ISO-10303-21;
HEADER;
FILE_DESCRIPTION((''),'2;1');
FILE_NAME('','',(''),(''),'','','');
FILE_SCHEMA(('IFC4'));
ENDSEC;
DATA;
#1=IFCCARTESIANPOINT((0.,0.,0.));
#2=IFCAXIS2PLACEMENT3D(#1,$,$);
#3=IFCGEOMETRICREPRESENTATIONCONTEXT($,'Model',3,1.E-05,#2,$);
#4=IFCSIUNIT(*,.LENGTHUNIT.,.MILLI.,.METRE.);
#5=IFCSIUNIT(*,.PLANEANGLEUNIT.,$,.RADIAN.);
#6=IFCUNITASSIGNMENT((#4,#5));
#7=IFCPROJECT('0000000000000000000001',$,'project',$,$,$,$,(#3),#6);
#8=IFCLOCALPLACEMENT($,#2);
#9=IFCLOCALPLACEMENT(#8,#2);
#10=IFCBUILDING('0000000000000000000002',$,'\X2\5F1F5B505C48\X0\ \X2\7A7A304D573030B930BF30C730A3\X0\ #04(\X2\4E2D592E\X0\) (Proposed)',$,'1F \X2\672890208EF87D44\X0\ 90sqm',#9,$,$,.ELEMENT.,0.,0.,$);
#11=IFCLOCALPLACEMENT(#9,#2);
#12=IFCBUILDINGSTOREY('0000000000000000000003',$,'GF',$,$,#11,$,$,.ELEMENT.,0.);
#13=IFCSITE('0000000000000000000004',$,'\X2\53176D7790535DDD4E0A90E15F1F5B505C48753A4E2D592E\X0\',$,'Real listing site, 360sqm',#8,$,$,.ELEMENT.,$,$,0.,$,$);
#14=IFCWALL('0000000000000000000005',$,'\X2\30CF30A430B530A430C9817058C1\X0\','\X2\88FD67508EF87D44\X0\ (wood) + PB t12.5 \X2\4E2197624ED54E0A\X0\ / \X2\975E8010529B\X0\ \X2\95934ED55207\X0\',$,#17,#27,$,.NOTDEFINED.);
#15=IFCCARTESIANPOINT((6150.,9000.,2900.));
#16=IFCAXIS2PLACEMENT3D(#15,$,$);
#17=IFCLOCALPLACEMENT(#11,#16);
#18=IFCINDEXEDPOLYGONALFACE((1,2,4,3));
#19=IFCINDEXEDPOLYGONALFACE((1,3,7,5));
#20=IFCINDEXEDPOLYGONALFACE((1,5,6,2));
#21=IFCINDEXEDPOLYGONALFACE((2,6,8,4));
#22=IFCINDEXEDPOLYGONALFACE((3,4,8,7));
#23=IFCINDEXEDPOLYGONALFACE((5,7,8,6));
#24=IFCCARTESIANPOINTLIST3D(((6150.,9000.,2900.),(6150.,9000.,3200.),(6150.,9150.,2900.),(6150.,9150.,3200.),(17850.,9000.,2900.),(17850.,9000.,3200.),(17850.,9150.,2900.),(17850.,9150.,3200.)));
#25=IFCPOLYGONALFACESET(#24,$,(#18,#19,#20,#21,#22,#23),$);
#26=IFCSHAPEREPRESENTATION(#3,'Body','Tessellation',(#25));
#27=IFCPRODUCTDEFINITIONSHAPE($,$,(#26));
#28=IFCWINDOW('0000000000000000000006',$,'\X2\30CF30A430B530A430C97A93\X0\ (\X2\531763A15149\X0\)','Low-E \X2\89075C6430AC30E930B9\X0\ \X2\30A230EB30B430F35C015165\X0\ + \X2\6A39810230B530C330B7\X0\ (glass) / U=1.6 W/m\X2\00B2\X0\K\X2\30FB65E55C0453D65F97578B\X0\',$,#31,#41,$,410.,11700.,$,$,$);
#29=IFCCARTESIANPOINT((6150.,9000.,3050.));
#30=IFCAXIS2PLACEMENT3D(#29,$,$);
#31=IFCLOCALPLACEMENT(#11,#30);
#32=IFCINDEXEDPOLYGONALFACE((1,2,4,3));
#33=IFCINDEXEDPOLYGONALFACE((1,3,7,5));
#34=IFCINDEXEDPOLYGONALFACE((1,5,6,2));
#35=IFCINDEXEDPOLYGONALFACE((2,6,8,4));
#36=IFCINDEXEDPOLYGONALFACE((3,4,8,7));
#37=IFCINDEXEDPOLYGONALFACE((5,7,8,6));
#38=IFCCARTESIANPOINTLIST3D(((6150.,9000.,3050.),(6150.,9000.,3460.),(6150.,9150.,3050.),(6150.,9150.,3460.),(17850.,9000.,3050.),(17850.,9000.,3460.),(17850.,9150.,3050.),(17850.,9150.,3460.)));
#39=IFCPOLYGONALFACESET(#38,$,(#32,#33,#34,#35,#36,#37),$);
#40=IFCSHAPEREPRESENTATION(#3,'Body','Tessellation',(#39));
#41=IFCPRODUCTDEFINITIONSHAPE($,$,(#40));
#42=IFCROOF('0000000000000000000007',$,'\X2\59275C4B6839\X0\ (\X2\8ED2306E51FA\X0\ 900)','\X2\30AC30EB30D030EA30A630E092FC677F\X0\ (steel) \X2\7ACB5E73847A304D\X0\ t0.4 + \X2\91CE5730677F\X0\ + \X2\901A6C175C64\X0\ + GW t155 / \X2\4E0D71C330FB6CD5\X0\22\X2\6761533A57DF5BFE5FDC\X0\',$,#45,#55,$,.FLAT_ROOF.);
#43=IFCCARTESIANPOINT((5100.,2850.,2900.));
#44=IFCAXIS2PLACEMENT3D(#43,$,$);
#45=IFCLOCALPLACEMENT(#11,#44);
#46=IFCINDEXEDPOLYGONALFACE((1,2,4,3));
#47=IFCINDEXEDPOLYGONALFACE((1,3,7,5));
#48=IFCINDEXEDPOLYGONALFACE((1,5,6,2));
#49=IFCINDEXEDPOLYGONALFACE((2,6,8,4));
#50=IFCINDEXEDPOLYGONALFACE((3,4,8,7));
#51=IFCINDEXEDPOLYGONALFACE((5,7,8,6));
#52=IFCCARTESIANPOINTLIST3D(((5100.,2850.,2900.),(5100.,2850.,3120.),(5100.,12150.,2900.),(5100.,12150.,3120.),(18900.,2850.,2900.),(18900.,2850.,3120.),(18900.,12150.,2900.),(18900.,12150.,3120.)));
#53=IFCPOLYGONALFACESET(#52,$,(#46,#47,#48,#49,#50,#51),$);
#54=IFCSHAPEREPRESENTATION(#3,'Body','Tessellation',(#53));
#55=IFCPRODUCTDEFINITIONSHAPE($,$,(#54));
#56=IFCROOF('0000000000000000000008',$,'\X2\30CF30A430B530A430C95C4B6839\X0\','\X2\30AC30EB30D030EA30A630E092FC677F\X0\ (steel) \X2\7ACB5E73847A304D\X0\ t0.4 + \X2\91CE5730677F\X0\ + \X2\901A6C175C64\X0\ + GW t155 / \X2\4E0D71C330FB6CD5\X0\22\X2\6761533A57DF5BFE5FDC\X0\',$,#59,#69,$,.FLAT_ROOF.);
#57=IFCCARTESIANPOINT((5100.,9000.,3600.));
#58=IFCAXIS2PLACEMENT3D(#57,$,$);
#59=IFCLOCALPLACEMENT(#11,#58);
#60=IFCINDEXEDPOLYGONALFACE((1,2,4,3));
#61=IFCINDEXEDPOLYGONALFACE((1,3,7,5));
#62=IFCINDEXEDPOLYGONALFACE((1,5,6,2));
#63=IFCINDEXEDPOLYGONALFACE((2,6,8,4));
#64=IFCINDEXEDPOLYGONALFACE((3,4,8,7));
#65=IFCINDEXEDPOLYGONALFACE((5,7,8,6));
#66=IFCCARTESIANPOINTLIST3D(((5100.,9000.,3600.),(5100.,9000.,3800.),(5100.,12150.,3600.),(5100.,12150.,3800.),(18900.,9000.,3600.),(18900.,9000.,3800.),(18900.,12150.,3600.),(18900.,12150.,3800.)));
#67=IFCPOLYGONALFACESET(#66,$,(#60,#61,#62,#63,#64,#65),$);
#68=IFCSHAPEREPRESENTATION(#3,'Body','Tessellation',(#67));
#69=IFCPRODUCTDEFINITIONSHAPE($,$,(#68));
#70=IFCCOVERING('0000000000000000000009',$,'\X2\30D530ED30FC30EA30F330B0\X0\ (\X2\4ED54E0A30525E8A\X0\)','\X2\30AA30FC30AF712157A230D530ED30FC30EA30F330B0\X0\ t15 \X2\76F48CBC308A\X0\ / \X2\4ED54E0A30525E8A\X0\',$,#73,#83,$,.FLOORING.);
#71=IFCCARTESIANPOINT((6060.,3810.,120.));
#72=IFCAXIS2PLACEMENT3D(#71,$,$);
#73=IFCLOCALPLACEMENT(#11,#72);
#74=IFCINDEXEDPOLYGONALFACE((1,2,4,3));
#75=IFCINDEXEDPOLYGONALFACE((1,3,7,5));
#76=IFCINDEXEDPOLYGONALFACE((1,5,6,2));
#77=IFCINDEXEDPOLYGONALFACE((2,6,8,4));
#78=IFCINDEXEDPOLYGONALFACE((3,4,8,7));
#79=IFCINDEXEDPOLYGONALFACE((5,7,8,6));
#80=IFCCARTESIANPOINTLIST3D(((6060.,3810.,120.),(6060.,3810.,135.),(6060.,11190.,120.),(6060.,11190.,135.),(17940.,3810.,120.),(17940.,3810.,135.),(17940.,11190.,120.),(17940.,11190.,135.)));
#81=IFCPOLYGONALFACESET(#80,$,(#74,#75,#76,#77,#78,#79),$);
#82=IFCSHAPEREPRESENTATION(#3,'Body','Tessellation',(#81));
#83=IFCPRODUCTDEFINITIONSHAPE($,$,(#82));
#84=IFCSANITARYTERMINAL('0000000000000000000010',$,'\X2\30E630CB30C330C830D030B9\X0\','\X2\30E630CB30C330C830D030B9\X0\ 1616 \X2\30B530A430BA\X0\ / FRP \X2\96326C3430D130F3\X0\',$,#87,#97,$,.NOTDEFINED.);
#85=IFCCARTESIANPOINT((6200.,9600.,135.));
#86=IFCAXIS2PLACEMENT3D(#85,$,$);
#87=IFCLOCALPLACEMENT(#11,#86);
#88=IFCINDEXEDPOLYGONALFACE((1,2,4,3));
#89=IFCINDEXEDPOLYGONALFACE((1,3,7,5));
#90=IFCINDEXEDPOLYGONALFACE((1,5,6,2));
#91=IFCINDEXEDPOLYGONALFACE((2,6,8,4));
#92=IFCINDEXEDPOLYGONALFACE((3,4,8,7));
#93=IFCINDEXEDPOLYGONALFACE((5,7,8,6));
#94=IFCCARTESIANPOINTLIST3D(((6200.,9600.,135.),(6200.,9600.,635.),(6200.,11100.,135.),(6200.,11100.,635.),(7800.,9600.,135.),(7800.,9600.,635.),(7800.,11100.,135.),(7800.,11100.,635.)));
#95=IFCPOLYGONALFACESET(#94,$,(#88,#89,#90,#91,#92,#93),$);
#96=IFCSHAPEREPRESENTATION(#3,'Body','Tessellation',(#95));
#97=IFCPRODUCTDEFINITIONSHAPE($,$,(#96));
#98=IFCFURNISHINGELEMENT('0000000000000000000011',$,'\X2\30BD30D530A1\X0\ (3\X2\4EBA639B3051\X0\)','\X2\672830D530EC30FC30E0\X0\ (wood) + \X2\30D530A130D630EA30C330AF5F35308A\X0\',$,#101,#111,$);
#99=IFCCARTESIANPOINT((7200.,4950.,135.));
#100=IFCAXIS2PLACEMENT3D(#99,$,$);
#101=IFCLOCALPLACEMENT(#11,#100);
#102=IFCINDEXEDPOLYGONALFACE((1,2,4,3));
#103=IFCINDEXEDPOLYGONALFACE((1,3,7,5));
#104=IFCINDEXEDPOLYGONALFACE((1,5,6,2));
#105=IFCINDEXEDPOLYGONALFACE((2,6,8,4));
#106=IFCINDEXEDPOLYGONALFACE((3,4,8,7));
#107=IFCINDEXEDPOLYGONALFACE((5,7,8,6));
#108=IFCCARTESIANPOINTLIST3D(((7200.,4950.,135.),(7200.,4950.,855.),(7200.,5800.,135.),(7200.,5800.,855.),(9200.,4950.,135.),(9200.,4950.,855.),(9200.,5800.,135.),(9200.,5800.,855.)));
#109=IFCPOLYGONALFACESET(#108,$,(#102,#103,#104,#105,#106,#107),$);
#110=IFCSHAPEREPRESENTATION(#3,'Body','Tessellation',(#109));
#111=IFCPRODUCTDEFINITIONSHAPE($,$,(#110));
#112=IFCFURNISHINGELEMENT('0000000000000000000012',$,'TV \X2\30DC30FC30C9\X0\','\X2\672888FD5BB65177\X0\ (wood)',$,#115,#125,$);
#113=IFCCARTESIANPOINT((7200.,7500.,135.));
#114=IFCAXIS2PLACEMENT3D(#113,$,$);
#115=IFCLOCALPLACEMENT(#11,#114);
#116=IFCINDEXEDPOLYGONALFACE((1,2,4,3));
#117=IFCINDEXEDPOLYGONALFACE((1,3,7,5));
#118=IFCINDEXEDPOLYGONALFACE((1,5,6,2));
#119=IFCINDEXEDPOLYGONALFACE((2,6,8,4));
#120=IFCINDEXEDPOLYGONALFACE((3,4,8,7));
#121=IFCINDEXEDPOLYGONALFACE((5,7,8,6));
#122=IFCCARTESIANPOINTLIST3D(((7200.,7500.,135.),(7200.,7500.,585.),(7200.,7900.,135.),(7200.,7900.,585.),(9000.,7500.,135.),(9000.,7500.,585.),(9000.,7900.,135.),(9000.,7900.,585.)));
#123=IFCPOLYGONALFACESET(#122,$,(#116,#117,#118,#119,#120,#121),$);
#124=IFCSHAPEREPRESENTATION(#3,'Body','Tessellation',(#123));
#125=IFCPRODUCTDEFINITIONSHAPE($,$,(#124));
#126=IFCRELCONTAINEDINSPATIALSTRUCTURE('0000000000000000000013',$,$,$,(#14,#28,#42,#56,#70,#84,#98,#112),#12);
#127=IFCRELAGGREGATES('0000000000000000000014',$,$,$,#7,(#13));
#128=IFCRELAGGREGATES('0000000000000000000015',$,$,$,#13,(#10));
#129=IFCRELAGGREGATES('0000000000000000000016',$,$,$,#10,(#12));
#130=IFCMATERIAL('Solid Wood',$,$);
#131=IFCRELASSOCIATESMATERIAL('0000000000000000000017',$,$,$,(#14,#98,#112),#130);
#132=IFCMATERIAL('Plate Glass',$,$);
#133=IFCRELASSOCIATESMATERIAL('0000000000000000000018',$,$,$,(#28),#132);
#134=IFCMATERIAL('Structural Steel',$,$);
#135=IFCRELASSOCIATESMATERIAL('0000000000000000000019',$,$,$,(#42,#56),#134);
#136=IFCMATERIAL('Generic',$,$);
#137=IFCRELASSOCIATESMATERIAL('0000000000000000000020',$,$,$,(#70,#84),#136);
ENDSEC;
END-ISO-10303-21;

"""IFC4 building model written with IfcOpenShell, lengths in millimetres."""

from ifc_helpers import new_model, si_unit, frame, frame_2d, origin, place, context, project, spatial, rectangle, extrude, material, element, fill, save


model = new_model("IFC4")

# Units and contexts
model_context = context("Model", 3, precision=1e-05, world=origin())
ifc_project = project(units=[si_unit("LENGTHUNIT", "METRE", prefix="MILLI"), si_unit("PLANEANGLEUNIT", "RADIAN")], contexts=[model_context])

# Site, building, storey
site_placement = place(None, origin())
site = spatial("IfcSite", under=ifc_project, at=site_placement, Name="北海道川上郡弟子屈町中央", ObjectType="Real listing site, 360sqm", CompositionType="ELEMENT", RefElevation=0.0)
building_placement = place(site_placement, origin())
building = spatial("IfcBuilding", under=site, at=building_placement, Name="弟子屈 空き地スタディ #04(中央) (Proposed)", ObjectType="1F 木造軸組 90sqm", CompositionType="ELEMENT", ElevationOfRefHeight=0.0, ElevationOfTerrain=0.0)
storey_placement = place(building_placement, origin())
storey = spatial("IfcBuildingStorey", under=building, at=storey_placement, Name="GF", CompositionType="ELEMENT", Elevation=0.0)

# Shared definitions
ifc_material_1 = material(Name="Solid Wood")

# Shared definitions
ifc_material_2 = material(Name="Plate Glass")

# Wall, opening, window
wall_1_placement = place(storey_placement, frame((6150.0, 9000.0, 2900.0)))
wall_1 = element("IfcWall", 1, at=wall_1_placement, inside=storey, material=ifc_material_1, Name="ハイサイド腰壁", Description="製材軸組 (wood) + PB t12.5 両面仕上 / 非耐力 間仕切", PredefinedType="NOTDEFINED", context=model_context, shape_type="SweptSolid", body=[
    extrude(rectangle(XDim=11700.0, YDim=150.0, at=frame_2d((5850.0, 75.0))), frame((6150.0, 9000.0, 2900.0)), (0.0, 0.0, 1.0), 700.0),
])
opening_1_placement = place(storey_placement, frame((6150.0, 9000.0, 3050.0)))
opening_1 = element("IfcOpeningElement", 2, at=opening_1_placement, cuts=wall_1, PredefinedType="NOTDEFINED", context=model_context, shape_type="SweptSolid", body=[
    extrude(rectangle(XDim=11700.0, YDim=150.0, at=frame_2d((5850.0, 75.0))), frame((6150.0, 9000.0, 3050.0)), (0.0, 0.0, 1.0), 410.0),
])
window_1_placement = place(storey_placement, frame((6150.0, 9000.0, 3050.0)))
window_1 = element("IfcWindow", 3, at=window_1_placement, inside=storey, material=ifc_material_2, Name="ハイサイド窓 (北採光)", Description="Low-E 複層ガラス アルゴン封入 + 樹脂サッシ (glass) / U=1.6 W/m²K・日射取得型", OverallHeight=410.0, OverallWidth=11700.0, context=model_context, shape_type="SweptSolid", body=[
    extrude(rectangle(XDim=11700.0, YDim=150.0, at=frame_2d((5850.0, 75.0))), frame((6150.0, 9000.0, 3050.0)), (0.0, 0.0, 1.0), 410.0),
])
fill(opening_1, window_1)

# Roofs
ifc_material_3 = material(Name="Structural Steel")
roof_1_placement = place(storey_placement, frame((5100.0, 2850.0, 2900.0)))
element("IfcRoof", 4, at=roof_1_placement, inside=storey, material=ifc_material_3, Name="大屋根 (軒の出 900)", Description="ガルバリウム鋼板 (steel) 立平葺き t0.4 + 野地板 + 通気層 + GW t155 / 不燃・法22条区域対応", PredefinedType="FLAT_ROOF", context=model_context, shape_type="SweptSolid", body=[
    extrude(rectangle(XDim=13800.0, YDim=9300.0, at=frame_2d((6900.0, 4650.0))), frame((5100.0, 2850.0, 2900.0)), (0.0, 0.0, 1.0), 220.0),
])
roof_2_placement = place(storey_placement, frame((5100.0, 9000.0, 3600.0)))
element("IfcRoof", 5, at=roof_2_placement, inside=storey, material=ifc_material_3, Name="ハイサイド屋根", Description="ガルバリウム鋼板 (steel) 立平葺き t0.4 + 野地板 + 通気層 + GW t155 / 不燃・法22条区域対応", PredefinedType="FLAT_ROOF", context=model_context, shape_type="SweptSolid", body=[
    extrude(rectangle(XDim=13800.0, YDim=3150.0, at=frame_2d((6900.0, 1575.0))), frame((5100.0, 9000.0, 3600.0)), (0.0, 0.0, 1.0), 200.0),
])

# Covering
ifc_material_4 = material(Name="Generic")
covering_placement = place(storey_placement, frame((6060.0, 3810.0, 120.0)))
element("IfcCovering", 6, at=covering_placement, inside=storey, material=ifc_material_4, Name="フローリング (仕上げ床)", Description="オーク無垢フローリング t15 直貼り / 仕上げ床", PredefinedType="FLOORING", context=model_context, shape_type="SweptSolid", body=[
    extrude(rectangle(XDim=11880.0, YDim=7380.0, at=frame_2d((5940.0, 3690.0))), frame((6060.0, 3810.0, 120.0)), (0.0, 0.0, 1.0), 15.0),
])

# Sanitary terminal
sanitary_terminal_placement = place(storey_placement, frame((6200.0, 9600.0, 135.0)))
element("IfcSanitaryTerminal", 7, at=sanitary_terminal_placement, inside=storey, material=ifc_material_4, Name="ユニットバス", Description="ユニットバス 1616 サイズ / FRP 防水パン", PredefinedType="NOTDEFINED", context=model_context, shape_type="SweptSolid", body=[
    extrude(rectangle(XDim=1600.0, YDim=1500.0, at=frame_2d((800.0, 750.0))), frame((6200.0, 9600.0, 135.0)), (0.0, 0.0, 1.0), 500.0),
])

# Furnishing elements
furnishing_1_placement = place(storey_placement, frame((7200.0, 4950.0, 135.0)))
element("IfcFurnishingElement", 8, at=furnishing_1_placement, inside=storey, material=ifc_material_1, Name="ソファ (3人掛け)", Description="木フレーム (wood) + ファブリック張り", context=model_context, shape_type="SweptSolid", body=[
    extrude(rectangle(XDim=2000.0, YDim=850.0, at=frame_2d((1000.0, 425.0))), frame((7200.0, 4950.0, 135.0)), (0.0, 0.0, 1.0), 720.0),
])
furnishing_2_placement = place(storey_placement, frame((7200.0, 7500.0, 135.0)))
element("IfcFurnishingElement", 9, at=furnishing_2_placement, inside=storey, material=ifc_material_1, Name="TV ボード", Description="木製家具 (wood)", context=model_context, shape_type="SweptSolid", body=[
    extrude(rectangle(XDim=1800.0, YDim=400.0, at=frame_2d((900.0, 200.0))), frame((7200.0, 7500.0, 135.0)), (0.0, 0.0, 1.0), 450.0),
])

save(model, "model.ifc")
